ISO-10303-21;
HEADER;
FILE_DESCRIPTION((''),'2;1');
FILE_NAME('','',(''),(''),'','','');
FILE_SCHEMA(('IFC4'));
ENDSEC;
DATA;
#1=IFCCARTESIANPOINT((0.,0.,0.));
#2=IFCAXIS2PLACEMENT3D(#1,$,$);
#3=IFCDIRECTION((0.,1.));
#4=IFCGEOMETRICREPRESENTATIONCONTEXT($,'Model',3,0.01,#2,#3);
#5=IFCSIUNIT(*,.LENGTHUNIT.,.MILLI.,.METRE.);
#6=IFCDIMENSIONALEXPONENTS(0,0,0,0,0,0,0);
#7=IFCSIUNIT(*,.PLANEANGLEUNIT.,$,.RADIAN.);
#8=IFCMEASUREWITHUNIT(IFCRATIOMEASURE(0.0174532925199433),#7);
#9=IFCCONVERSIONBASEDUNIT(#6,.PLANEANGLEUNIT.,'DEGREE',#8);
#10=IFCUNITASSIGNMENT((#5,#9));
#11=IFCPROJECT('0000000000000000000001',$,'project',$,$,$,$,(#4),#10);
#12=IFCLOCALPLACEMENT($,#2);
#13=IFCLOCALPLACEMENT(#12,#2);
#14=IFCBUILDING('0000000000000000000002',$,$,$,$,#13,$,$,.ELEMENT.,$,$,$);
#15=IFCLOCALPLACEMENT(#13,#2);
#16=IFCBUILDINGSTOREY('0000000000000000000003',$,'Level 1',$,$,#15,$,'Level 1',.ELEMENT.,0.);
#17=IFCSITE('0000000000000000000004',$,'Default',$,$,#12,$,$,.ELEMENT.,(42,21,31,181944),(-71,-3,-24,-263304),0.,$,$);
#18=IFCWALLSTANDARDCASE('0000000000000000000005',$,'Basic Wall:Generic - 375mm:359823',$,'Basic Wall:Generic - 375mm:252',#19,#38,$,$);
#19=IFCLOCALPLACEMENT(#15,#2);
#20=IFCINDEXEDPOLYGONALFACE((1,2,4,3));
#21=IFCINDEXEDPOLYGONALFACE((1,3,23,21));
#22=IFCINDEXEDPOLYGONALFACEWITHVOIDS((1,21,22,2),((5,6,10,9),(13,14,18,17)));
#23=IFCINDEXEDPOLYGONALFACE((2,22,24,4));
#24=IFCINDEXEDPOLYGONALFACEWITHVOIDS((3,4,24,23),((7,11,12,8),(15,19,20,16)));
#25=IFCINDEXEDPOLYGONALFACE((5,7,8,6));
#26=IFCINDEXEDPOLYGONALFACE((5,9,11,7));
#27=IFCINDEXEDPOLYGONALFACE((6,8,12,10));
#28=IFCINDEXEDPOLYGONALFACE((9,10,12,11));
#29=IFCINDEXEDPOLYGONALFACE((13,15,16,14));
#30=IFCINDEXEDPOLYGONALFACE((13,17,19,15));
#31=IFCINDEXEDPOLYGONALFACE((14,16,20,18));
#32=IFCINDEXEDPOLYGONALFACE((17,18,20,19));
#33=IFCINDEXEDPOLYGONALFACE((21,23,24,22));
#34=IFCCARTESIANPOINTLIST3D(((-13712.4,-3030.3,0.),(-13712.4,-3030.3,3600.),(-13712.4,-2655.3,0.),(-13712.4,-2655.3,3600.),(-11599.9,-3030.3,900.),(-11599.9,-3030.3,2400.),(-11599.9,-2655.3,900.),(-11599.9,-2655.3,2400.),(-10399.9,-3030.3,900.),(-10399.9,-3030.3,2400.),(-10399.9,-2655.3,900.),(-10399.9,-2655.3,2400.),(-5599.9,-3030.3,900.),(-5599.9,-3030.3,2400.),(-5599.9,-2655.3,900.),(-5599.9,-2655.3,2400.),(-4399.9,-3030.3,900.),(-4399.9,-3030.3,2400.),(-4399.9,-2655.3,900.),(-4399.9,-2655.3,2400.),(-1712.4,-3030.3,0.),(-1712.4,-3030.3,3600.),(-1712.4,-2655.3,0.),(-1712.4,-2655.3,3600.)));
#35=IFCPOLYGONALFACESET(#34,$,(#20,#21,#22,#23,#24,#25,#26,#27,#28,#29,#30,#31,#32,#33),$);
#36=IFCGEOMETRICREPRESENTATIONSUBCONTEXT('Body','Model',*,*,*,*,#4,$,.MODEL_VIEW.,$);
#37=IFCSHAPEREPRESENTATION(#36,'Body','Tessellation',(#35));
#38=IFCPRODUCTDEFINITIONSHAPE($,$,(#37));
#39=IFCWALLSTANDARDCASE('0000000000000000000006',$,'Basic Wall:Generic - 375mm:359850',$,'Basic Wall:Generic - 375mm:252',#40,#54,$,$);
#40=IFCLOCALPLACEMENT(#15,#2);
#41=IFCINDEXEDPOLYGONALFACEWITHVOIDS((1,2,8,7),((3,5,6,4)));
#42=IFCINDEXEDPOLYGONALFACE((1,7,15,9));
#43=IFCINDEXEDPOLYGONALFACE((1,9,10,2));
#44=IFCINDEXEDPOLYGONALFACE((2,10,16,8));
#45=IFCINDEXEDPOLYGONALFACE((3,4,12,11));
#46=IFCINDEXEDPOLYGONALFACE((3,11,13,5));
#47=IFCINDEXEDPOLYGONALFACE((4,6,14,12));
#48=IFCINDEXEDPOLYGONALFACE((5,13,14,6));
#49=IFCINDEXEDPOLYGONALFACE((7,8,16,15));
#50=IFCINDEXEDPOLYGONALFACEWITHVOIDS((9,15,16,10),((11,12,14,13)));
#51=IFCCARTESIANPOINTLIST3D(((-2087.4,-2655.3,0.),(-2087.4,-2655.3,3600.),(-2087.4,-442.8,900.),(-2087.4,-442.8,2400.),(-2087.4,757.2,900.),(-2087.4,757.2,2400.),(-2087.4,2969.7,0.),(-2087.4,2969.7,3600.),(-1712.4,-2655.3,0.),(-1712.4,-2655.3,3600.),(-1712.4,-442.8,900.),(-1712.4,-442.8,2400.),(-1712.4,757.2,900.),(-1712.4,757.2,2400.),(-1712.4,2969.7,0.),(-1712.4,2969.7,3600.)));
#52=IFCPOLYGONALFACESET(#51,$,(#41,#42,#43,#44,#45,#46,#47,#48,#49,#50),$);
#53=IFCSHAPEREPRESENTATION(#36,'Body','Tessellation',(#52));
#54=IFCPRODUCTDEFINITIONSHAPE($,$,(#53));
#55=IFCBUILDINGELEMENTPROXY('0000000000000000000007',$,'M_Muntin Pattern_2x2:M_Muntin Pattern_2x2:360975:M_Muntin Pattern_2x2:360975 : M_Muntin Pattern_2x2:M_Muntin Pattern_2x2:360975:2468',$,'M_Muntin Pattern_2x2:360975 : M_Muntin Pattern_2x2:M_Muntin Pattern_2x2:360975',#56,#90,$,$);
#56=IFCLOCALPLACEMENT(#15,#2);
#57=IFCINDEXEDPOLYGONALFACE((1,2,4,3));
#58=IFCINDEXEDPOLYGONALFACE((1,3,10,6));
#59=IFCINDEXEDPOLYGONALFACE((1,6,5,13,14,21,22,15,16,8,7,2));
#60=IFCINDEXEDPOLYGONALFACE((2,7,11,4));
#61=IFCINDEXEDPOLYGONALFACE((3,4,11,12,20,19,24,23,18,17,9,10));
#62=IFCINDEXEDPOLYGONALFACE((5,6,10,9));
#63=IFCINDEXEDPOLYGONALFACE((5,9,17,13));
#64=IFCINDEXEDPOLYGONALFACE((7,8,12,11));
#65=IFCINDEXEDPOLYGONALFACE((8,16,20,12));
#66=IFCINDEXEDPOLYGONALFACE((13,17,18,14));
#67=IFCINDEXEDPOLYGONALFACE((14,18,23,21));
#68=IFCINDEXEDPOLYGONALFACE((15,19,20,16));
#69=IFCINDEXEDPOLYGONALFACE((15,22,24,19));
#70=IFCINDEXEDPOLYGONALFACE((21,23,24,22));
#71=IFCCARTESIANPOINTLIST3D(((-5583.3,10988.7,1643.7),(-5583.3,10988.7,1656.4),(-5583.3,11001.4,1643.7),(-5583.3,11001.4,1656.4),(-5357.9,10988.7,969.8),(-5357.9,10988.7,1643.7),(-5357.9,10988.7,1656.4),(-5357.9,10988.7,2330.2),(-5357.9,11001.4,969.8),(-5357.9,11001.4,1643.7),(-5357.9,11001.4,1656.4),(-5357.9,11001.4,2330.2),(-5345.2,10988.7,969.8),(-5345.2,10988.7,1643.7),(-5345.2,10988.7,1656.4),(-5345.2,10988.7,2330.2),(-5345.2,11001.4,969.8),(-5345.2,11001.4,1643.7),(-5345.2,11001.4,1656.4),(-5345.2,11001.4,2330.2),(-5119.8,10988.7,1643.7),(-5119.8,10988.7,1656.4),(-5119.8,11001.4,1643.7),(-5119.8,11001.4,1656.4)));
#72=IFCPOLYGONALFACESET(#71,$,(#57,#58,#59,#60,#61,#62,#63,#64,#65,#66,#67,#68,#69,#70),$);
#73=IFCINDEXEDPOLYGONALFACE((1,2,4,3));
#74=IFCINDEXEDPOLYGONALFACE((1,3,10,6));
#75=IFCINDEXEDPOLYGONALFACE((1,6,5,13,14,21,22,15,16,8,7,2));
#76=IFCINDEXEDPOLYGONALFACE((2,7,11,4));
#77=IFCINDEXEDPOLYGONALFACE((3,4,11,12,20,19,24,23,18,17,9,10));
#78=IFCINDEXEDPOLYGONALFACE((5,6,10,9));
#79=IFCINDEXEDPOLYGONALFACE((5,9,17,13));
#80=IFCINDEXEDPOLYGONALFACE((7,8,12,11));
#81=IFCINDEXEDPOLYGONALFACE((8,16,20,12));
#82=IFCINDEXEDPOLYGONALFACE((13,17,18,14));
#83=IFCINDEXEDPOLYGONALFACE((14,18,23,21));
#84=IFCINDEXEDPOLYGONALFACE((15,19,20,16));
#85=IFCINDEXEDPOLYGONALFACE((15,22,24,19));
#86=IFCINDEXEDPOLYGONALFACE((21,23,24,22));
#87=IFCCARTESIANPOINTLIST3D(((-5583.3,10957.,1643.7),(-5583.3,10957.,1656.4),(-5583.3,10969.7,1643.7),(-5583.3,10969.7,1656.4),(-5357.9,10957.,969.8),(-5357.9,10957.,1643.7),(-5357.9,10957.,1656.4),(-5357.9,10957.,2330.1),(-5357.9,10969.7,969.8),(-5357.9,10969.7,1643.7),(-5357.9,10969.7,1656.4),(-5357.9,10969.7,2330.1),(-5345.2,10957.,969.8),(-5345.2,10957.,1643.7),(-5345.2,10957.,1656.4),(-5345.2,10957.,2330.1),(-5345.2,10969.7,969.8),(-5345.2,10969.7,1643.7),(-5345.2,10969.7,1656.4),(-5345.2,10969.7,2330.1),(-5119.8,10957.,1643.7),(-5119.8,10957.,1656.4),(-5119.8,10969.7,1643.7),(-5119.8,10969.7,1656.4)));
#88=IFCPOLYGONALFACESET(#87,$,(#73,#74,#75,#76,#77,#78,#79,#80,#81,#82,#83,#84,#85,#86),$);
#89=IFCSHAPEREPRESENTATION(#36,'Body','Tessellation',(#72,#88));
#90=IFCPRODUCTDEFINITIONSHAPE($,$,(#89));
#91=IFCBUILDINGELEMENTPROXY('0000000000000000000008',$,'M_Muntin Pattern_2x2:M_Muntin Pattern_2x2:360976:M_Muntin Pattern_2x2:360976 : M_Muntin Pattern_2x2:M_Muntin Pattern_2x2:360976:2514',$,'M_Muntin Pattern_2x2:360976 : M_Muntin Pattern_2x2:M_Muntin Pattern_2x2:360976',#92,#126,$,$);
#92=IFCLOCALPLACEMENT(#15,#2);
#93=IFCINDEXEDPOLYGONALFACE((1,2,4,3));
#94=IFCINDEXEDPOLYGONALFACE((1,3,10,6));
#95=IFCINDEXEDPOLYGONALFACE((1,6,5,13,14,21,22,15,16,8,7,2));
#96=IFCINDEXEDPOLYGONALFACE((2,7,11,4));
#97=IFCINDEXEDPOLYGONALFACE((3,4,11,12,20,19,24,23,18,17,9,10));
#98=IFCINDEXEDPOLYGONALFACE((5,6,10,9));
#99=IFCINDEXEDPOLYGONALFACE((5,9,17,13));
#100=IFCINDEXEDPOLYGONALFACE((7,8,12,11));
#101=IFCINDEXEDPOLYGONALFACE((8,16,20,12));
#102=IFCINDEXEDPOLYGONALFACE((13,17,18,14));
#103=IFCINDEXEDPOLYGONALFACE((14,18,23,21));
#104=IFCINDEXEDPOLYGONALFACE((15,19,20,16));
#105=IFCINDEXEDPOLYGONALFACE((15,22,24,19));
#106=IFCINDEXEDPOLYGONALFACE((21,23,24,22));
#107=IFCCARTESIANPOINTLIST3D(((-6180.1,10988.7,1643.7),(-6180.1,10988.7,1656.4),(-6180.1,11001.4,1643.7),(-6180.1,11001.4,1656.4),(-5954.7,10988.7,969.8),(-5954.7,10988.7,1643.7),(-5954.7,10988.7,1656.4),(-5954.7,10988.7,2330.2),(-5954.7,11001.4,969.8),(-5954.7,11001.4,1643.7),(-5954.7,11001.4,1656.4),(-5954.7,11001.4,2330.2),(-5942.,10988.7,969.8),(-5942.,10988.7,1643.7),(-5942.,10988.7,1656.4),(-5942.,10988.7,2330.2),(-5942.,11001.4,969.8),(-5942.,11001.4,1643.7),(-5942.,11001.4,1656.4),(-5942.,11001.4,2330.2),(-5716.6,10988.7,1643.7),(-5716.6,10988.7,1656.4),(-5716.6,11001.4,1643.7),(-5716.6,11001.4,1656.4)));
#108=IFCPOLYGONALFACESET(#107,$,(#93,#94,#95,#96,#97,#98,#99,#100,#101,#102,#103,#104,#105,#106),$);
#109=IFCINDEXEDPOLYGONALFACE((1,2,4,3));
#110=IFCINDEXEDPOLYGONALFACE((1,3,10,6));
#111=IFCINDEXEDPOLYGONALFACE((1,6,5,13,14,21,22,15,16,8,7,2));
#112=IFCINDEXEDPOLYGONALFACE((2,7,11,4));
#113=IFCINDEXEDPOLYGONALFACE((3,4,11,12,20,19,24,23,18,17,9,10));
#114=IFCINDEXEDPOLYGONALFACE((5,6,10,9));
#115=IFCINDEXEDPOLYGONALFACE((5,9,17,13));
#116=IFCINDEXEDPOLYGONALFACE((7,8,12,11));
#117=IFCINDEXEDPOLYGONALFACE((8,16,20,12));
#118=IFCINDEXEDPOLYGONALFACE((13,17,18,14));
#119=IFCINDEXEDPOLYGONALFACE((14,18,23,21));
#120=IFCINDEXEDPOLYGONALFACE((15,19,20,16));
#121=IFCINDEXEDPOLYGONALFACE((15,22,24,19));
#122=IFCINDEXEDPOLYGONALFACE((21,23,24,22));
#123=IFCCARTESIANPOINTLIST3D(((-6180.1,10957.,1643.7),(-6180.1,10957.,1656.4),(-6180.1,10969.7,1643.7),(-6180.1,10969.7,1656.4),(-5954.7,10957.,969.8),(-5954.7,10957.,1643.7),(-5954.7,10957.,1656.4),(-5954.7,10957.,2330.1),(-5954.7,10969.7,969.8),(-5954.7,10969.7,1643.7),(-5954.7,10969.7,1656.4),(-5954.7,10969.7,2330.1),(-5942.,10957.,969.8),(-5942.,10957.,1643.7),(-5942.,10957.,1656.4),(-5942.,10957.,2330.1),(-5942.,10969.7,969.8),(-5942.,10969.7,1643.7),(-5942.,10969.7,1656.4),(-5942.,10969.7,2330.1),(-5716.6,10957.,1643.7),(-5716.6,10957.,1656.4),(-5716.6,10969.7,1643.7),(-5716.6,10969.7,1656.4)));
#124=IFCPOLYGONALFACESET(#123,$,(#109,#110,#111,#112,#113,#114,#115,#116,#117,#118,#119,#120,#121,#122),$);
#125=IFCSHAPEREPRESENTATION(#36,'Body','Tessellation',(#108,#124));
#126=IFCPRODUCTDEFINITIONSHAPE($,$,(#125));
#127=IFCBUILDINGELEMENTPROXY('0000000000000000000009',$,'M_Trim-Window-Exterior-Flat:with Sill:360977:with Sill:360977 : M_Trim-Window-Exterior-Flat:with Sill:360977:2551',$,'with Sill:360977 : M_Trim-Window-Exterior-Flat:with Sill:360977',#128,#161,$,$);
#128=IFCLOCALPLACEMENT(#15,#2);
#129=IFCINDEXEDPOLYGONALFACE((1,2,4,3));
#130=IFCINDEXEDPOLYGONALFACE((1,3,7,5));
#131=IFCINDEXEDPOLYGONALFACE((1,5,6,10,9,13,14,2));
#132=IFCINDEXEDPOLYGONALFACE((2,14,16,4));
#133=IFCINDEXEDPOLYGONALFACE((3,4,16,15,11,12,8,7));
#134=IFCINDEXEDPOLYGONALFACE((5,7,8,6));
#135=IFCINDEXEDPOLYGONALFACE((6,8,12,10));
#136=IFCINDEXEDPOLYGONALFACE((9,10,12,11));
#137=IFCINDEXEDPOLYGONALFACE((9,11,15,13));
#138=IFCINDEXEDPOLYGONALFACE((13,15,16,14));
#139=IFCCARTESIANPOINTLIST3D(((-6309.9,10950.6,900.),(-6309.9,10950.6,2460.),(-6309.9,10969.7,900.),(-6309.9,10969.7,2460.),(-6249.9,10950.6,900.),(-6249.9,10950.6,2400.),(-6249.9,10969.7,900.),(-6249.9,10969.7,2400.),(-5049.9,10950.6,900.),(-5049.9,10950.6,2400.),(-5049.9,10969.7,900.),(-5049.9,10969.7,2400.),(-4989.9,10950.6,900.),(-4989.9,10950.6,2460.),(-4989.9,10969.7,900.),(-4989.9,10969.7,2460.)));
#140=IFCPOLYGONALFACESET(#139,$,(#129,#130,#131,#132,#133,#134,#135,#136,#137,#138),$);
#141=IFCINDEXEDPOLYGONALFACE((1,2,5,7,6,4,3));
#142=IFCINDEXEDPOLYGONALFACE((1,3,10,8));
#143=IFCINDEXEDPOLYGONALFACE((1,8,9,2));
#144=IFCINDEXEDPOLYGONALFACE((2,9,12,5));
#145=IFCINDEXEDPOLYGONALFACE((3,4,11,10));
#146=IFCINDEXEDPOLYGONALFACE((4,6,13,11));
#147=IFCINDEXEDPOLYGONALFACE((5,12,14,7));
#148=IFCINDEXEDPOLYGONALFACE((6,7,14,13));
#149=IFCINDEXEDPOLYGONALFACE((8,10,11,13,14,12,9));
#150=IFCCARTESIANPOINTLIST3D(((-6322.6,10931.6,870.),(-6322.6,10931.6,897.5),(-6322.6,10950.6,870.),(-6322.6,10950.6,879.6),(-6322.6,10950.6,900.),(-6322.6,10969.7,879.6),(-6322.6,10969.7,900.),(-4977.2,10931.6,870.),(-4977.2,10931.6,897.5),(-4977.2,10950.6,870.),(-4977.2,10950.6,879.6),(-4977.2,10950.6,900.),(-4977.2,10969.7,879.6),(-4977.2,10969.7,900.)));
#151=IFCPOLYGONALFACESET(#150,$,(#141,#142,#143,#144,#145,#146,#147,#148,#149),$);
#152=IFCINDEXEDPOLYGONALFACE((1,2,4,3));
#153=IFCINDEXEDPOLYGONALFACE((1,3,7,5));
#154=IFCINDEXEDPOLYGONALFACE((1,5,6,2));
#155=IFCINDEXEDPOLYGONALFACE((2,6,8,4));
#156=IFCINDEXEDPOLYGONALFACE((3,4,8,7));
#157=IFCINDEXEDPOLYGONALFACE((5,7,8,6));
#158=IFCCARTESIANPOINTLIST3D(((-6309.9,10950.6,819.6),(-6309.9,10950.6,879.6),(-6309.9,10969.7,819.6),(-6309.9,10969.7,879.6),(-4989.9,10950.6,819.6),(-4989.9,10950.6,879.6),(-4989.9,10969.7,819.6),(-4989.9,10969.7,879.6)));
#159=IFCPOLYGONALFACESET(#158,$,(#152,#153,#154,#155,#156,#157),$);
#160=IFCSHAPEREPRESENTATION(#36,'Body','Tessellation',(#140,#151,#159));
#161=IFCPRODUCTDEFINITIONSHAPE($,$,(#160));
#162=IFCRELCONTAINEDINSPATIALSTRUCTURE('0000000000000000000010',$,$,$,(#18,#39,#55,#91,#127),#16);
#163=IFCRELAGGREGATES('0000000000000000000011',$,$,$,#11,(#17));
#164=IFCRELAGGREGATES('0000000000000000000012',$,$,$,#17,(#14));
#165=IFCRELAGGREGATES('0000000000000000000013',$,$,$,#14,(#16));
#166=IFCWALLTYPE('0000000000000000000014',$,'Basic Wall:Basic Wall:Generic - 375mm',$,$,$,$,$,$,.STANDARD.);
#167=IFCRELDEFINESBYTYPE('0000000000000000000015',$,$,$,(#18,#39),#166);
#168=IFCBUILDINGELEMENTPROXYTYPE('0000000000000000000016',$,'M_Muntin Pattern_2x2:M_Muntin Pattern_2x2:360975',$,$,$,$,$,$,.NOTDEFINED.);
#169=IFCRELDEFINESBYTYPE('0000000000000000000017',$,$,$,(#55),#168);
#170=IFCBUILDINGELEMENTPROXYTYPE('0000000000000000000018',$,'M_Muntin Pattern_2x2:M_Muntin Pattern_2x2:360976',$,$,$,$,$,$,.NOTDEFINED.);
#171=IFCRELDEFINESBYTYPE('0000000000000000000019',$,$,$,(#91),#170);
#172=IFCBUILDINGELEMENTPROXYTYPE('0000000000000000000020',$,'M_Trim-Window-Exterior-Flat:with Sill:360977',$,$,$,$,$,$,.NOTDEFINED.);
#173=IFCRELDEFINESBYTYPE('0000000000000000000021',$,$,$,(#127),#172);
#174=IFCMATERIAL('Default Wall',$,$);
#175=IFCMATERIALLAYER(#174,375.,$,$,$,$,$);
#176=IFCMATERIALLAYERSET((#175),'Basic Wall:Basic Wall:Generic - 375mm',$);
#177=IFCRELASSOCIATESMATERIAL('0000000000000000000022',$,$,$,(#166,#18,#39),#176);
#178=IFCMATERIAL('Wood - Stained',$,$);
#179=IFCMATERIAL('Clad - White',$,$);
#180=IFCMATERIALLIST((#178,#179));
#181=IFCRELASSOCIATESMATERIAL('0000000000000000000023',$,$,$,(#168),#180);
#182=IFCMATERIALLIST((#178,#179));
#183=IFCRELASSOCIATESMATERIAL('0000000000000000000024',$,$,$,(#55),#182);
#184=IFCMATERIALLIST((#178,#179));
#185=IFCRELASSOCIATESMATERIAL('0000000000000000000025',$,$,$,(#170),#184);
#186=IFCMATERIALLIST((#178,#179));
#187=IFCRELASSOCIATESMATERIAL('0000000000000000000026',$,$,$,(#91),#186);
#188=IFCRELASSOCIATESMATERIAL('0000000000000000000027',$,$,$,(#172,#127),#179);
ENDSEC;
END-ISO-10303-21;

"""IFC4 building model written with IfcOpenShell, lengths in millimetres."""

from ifc_helpers import new_model, entity, si_unit, converted_unit, direction, frame, frame_2d, origin, place, context, subcontext, project, spatial, polyline, rectangle, outline, extrude, source, transform, mapped, material, material_list, layer, layer_set, layer_usage, type_object, type_shapes, element, save


model = new_model("IFC4")

# Units and contexts
model_context = context("Model", 3, precision=0.01, world=origin(), true_north=direction((0.0, 1.0)))
body_context = subcontext(model_context, "Body", "Model", "MODEL_VIEW")
ifc_project = project(units=[si_unit("LENGTHUNIT", "METRE", prefix="MILLI"), converted_unit("PLANEANGLEUNIT", "DEGREE", entity("IfcRatioMeasure", 0.0174532925199433), si_unit("PLANEANGLEUNIT", "RADIAN"), dimensions=[0, 0, 0, 0, 0, 0, 0])], contexts=[model_context])

# Site, building, storey
site_placement = place(None, origin())
site = spatial("IfcSite", under=ifc_project, at=site_placement, Name="Default", CompositionType="ELEMENT", RefLatitude=(42, 21, 31, 181944), RefLongitude=(-71, -3, -24, -263304), RefElevation=0.0)
building_placement = place(site_placement, origin())
building = spatial("IfcBuilding", under=site, at=building_placement, CompositionType="ELEMENT")
storey_placement = place(building_placement, origin())
storey = spatial("IfcBuildingStorey", under=building, at=storey_placement, Name="Level 1", LongName="Level 1", CompositionType="ELEMENT", Elevation=0.0)

# Wall, openings
ifc_material_1 = material(Name="Default Wall")
ifc_layer = layer(ifc_material_1, 375.0)
ifc_layer_set = layer_set([ifc_layer], Name="Basic Wall:Basic Wall:Generic - 375mm")
ifc_layer_usage_1 = layer_usage(ifc_layer_set, "AXIS2", "NEGATIVE", 187.5)
wall_type = type_object("IfcWallType", Name="Basic Wall:Basic Wall:Generic - 375mm", PredefinedType="STANDARD", material=ifc_layer_set)
wall_1_placement = place(storey_placement, frame((-13712.4, -2842.8, 0.0)))
wall_1 = element("IfcWallStandardCase", 1, at=wall_1_placement, inside=storey, type_object=wall_type, material=ifc_layer_usage_1, Name="Basic Wall:Generic - 375mm:359823", ObjectType="Basic Wall:Generic - 375mm:252", context=body_context, shape_type="SweptSolid", body=[
    extrude(rectangle(XDim=12000.0, YDim=375.0, at=frame_2d((6000.0, 0.0), x_axis=(-1.0, 0.0))), origin(), (0.0, 0.0, 1.0), 3600.0),
])
opening_1_placement = place(wall_1_placement, frame((13712.4, 2842.8, 0.0)))
element("IfcOpeningElement", 2, at=opening_1_placement, cuts=wall_1, ObjectType="Opening", context=body_context, shape_type="SweptSolid", body=[
    extrude(rectangle(XDim=1500.0, YDim=1200.0, at=frame_2d((0.0, 0.0), x_axis=(0.0, 1.0))), frame((-10999.9, -3034.1, 1650.0), z_axis=(0.0, 1.0, 0.0), x_axis=(-1.0, 0.0, 0.0)), (0.0, 0.0, 1.0), 382.5),
])
opening_2_placement = place(wall_1_placement, frame((13712.4, 2842.8, 0.0)))
element("IfcOpeningElement", 3, at=opening_2_placement, cuts=wall_1, ObjectType="Opening", context=body_context, shape_type="SweptSolid", body=[
    extrude(rectangle(XDim=1500.0, YDim=1200.0, at=frame_2d((0.0, 0.0), x_axis=(0.0, 1.0))), frame((-4999.9, -3034.1, 1650.0), z_axis=(0.0, 1.0, 0.0), x_axis=(-1.0, 0.0, 0.0)), (0.0, 0.0, 1.0), 382.5),
])

# Wall, opening
ifc_layer_usage_2 = layer_usage(ifc_layer_set, "AXIS2", "NEGATIVE", 187.5)
wall_2_placement = place(storey_placement, frame((-1899.9, -2655.3, 0.0), z_axis=(0.0, 0.0, 1.0), x_axis=(0.0, 1.0, 0.0)))
wall_2 = element("IfcWallStandardCase", 4, at=wall_2_placement, inside=storey, type_object=wall_type, material=ifc_layer_usage_2, Name="Basic Wall:Generic - 375mm:359850", ObjectType="Basic Wall:Generic - 375mm:252", context=body_context, shape_type="SweptSolid", body=[
    extrude(rectangle(XDim=5625.0, YDim=375.0, at=frame_2d((2812.5, 0.0), x_axis=(-1.0, 0.0))), origin(), (0.0, 0.0, 1.0), 3600.0),
])
opening_3_placement = place(wall_2_placement, frame((2655.3, -1899.9, 0.0), z_axis=(0.0, 0.0, 1.0), x_axis=(0.0, -1.0, 0.0)))
element("IfcOpeningElement", 5, at=opening_3_placement, cuts=wall_2, ObjectType="Opening", context=body_context, shape_type="SweptSolid", body=[
    extrude(rectangle(XDim=1500.0, YDim=1200.0, at=frame_2d((0.0, 0.0), x_axis=(0.0, 1.0))), frame((-1708.7, 157.2, 1650.0), z_axis=(-1.0, 0.0, 0.0), x_axis=(0.0, -1.0, 0.0)), (0.0, 0.0, 1.0), 382.5),
])

# Building element proxies
ifc_material_2 = material(Name="Wood - Stained")
ifc_material_3 = material(Name="Clad - White")
ifc_material_list_1 = material_list([ifc_material_2, ifc_material_3])
ifc_material_list_2 = material_list([ifc_material_2, ifc_material_3])
building_element_proxy_type_1 = type_object("IfcBuildingElementProxyType", Name="M_Muntin Pattern_2x2:M_Muntin Pattern_2x2:360975", PredefinedType="NOTDEFINED", material=ifc_material_list_2)
shared_shape_1 = source(origin(), body_context, "Body", "SweptSolid", [
    extrude(outline(polyline([(-680.2, 6.4), (-680.2, -6.3), (-6.4, -6.3), (-6.4, -231.7), (6.3, -231.7), (6.3, -6.3), (680.2, -6.3), (680.2, 6.4), (6.3, 6.4), (6.3, 231.7), (-6.4, 231.7), (-6.4, 6.4), (-680.2, 6.4)])), frame((-5351.5, 10988.7, 1650.0), z_axis=(0.0, -1.0, 0.0), x_axis=(0.0, 0.0, -1.0)), (0.0, 0.0, -1.0), 12.7),
    extrude(outline(polyline([(-680.1, 6.4), (-680.1, -6.3), (-6.4, -6.3), (-6.4, -231.7), (6.3, -231.7), (6.3, -6.3), (680.2, -6.3), (680.2, 6.4), (6.3, 6.4), (6.3, 231.7), (-6.4, 231.7), (-6.4, 6.4), (-680.1, 6.4)])), frame((-5351.5, 10957.0, 1650.0), z_axis=(0.0, -1.0, 0.0), x_axis=(0.0, 0.0, -1.0)), (0.0, 0.0, -1.0), 12.7),
])
type_shapes(building_element_proxy_type_1, [shared_shape_1])
proxy_1_placement = place(storey_placement, origin())
element("IfcBuildingElementProxy", 6, at=proxy_1_placement, inside=storey, type_object=building_element_proxy_type_1, material=ifc_material_list_1, Name="M_Muntin Pattern_2x2:M_Muntin Pattern_2x2:360975:M_Muntin Pattern_2x2:360975 : M_Muntin Pattern_2x2:M_Muntin Pattern_2x2:360975:2468", ObjectType="M_Muntin Pattern_2x2:360975 : M_Muntin Pattern_2x2:M_Muntin Pattern_2x2:360975", context=body_context, shape_type="MappedRepresentation", body=[
    mapped(shared_shape_1, transform((0.0, 0.0, 0.0), scale=1.0)),
])
ifc_material_list_3 = material_list([ifc_material_2, ifc_material_3])
ifc_material_list_4 = material_list([ifc_material_2, ifc_material_3])
building_element_proxy_type_2 = type_object("IfcBuildingElementProxyType", Name="M_Muntin Pattern_2x2:M_Muntin Pattern_2x2:360976", PredefinedType="NOTDEFINED", material=ifc_material_list_4)
shared_shape_2 = source(origin(), body_context, "Body", "SweptSolid", [
    extrude(outline(polyline([(-6.4, -680.1), (6.3, -680.1), (6.3, -6.4), (231.7, -6.4), (231.7, 6.3), (6.3, 6.3), (6.3, 680.2), (-6.4, 680.2), (-6.4, 6.3), (-231.7, 6.3), (-231.7, -6.4), (-6.4, -6.4), (-6.4, -680.1)])), frame((-5948.4, 10988.7, 1650.0), z_axis=(0.0, 1.0, 0.0), x_axis=(1.0, 0.0, 0.0)), (0.0, 0.0, 1.0), 12.7),
    extrude(outline(polyline([(-6.4, -680.1), (6.3, -680.1), (6.3, -6.4), (231.7, -6.4), (231.7, 6.3), (6.3, 6.3), (6.3, 680.2), (-6.4, 680.2), (-6.4, 6.3), (-231.7, 6.3), (-231.7, -6.4), (-6.4, -6.4), (-6.4, -680.1)])), frame((-5948.4, 10957.0, 1650.0), z_axis=(0.0, 1.0, 0.0), x_axis=(1.0, 0.0, 0.0)), (0.0, 0.0, 1.0), 12.7),
])
type_shapes(building_element_proxy_type_2, [shared_shape_2])
proxy_2_placement = place(storey_placement, origin())
element("IfcBuildingElementProxy", 7, at=proxy_2_placement, inside=storey, type_object=building_element_proxy_type_2, material=ifc_material_list_3, Name="M_Muntin Pattern_2x2:M_Muntin Pattern_2x2:360976:M_Muntin Pattern_2x2:360976 : M_Muntin Pattern_2x2:M_Muntin Pattern_2x2:360976:2514", ObjectType="M_Muntin Pattern_2x2:360976 : M_Muntin Pattern_2x2:M_Muntin Pattern_2x2:360976", context=body_context, shape_type="MappedRepresentation", body=[
    mapped(shared_shape_2, transform((0.0, 0.0, 0.0), scale=1.0)),
])
building_element_proxy_type_3 = type_object("IfcBuildingElementProxyType", Name="M_Trim-Window-Exterior-Flat:with Sill:360977", PredefinedType="NOTDEFINED", material=ifc_material_3)
shared_shape_3 = source(origin(), body_context, "Body", "SweptSolid", [
    extrude(outline(polyline([(-765.0, -660.0), (795.0, -660.0), (795.0, 660.0), (-765.0, 660.0), (-765.0, 600.0), (735.0, 600.0), (735.0, -600.0), (-765.0, -600.0), (-765.0, -660.0)])), frame((-5649.9, 10950.6, 1665.0), z_axis=(0.0, 1.0, 0.0), x_axis=(0.0, 0.0, 1.0)), (0.0, 0.0, 1.0), 19.1),
    extrude(outline(polyline([(-15.2, 0.0), (-15.2, -19.0), (12.3, -19.0), (14.8, 0.0), (14.8, 19.0), (-5.7, 19.0), (-5.7, 0.0), (-15.2, 0.0)])), frame((-6322.6, 10950.6, 885.2), z_axis=(-1.0, 0.0, 0.0), x_axis=(0.0, 0.0, 1.0)), (0.0, 0.0, -1.0), 1345.4),
    extrude(rectangle(XDim=19.1, YDim=1320.0, at=frame_2d((0.0, 0.0), x_axis=(1.0, 0.0))), frame((-5649.9, 10960.1, 819.6), z_axis=(0.0, 0.0, 1.0), x_axis=(0.0, 1.0, 0.0)), (0.0, 0.0, 1.0), 60.0),
])
type_shapes(building_element_proxy_type_3, [shared_shape_3])
proxy_3_placement = place(storey_placement, origin())
element("IfcBuildingElementProxy", 8, at=proxy_3_placement, inside=storey, type_object=building_element_proxy_type_3, material=ifc_material_3, Name="M_Trim-Window-Exterior-Flat:with Sill:360977:with Sill:360977 : M_Trim-Window-Exterior-Flat:with Sill:360977:2551", ObjectType="with Sill:360977 : M_Trim-Window-Exterior-Flat:with Sill:360977", context=body_context, shape_type="MappedRepresentation", body=[
    mapped(shared_shape_3, transform((0.0, 0.0, 0.0), scale=1.0)),
])

save(model, "model.ifc")
